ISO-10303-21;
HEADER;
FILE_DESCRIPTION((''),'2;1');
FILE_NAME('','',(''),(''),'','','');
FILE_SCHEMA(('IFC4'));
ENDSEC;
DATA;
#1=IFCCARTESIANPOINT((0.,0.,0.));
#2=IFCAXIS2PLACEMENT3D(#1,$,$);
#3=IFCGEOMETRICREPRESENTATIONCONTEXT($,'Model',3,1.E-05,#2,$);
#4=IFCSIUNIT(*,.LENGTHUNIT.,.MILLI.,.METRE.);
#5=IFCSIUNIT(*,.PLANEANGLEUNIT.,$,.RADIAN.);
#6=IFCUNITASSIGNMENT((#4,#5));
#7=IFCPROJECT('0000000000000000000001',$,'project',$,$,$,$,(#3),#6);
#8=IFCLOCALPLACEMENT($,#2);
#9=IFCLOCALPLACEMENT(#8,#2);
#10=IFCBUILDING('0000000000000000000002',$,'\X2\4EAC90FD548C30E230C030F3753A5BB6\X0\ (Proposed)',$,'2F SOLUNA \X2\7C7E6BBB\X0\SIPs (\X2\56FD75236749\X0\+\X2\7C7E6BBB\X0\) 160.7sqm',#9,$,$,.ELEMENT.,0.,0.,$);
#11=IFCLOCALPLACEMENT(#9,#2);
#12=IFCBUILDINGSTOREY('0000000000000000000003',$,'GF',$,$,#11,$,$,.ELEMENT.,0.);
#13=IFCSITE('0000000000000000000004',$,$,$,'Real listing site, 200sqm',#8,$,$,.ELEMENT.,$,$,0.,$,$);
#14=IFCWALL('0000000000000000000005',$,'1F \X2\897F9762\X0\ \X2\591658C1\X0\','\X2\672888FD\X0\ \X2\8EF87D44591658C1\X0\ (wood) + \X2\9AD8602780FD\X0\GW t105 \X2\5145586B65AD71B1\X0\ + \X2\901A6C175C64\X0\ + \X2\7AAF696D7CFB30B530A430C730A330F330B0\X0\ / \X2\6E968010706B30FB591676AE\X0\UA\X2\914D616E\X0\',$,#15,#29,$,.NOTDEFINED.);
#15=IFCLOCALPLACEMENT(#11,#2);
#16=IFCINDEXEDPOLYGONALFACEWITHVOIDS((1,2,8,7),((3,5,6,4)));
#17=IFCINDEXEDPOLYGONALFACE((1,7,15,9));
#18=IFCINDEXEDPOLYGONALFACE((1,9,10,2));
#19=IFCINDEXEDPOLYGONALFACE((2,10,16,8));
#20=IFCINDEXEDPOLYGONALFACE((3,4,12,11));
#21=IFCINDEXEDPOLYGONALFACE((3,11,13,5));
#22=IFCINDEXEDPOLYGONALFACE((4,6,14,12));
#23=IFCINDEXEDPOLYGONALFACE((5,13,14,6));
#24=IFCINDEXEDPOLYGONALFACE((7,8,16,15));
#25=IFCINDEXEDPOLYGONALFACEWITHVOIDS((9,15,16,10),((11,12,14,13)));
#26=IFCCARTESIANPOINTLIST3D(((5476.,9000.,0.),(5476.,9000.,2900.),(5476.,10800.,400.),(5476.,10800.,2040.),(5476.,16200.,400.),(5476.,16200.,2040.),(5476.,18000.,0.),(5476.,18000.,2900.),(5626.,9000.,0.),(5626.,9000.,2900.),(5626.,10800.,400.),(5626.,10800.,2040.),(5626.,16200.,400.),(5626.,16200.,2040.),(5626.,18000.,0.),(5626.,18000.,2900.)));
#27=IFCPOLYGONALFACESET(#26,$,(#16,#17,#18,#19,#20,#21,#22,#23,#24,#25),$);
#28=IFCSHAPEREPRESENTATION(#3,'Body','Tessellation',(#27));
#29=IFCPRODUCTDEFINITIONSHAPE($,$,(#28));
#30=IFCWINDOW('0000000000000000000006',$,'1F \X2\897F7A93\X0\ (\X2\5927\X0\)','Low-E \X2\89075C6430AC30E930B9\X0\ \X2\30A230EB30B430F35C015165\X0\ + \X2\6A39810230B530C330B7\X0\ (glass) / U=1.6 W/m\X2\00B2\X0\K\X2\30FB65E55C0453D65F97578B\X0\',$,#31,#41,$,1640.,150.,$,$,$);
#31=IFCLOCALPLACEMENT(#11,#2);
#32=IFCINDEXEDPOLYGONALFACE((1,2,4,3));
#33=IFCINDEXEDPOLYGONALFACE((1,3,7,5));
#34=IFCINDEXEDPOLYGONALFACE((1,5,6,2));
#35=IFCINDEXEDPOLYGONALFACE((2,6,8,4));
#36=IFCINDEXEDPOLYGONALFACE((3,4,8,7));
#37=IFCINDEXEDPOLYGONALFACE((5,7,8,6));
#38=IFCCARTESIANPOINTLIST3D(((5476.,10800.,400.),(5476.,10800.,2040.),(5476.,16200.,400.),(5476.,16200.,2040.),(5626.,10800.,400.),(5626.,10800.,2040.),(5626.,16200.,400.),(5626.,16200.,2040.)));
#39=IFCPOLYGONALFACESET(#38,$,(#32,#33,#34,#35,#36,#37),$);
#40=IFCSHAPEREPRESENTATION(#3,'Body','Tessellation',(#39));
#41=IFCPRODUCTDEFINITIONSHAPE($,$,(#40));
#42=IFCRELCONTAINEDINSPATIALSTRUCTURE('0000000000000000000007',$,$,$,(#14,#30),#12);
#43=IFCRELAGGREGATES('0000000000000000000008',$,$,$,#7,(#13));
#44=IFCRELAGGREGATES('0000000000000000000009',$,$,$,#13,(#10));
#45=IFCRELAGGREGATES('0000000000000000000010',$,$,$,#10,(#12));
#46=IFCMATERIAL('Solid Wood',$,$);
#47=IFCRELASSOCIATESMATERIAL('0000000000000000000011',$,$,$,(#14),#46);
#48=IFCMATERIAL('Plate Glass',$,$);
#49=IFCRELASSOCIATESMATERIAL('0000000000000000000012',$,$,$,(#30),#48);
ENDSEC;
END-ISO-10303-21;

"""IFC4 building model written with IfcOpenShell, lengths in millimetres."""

from ifc_helpers import new_model, si_unit, frame, frame_2d, origin, place, context, project, spatial, rectangle, extrude, material, element, fill, save


model = new_model("IFC4")

# Units and contexts
model_context = context("Model", 3, precision=1e-05, world=origin())
ifc_project = project(units=[si_unit("LENGTHUNIT", "METRE", prefix="MILLI"), si_unit("PLANEANGLEUNIT", "RADIAN")], contexts=[model_context])

# Site, building, storey
site_placement = place(None, origin())
site = spatial("IfcSite", under=ifc_project, at=site_placement, ObjectType="Real listing site, 200sqm", CompositionType="ELEMENT", RefElevation=0.0)
building_placement = place(site_placement, origin())
building = spatial("IfcBuilding", under=site, at=building_placement, Name="京都和モダン町家 (Proposed)", ObjectType="2F SOLUNA 籾殻SIPs (国産杉+籾殻) 160.7sqm", CompositionType="ELEMENT", ElevationOfRefHeight=0.0, ElevationOfTerrain=0.0)
storey_placement = place(building_placement, origin())
storey = spatial("IfcBuildingStorey", under=building, at=storey_placement, Name="GF", CompositionType="ELEMENT", Elevation=0.0)

# Shared definitions
ifc_material_1 = material(Name="Solid Wood")

# Shared definitions
ifc_material_2 = material(Name="Plate Glass")

# Wall, opening, window
wall_1_placement = place(storey_placement, frame((2738.0, 4500.0, 0.0)))
wall_1 = element("IfcWall", 1, at=wall_1_placement, inside=storey, material=ifc_material_1, Name="1F 西面 外壁", Description="木製 軸組外壁 (wood) + 高性能GW t105 充填断熱 + 通気層 + 窯業系サイディング / 準耐火・外皮UA配慮", PredefinedType="NOTDEFINED", context=model_context, shape_type="SweptSolid", body=[
    extrude(rectangle(XDim=150.0, YDim=9000.0, at=frame_2d((75.0, 4500.0))), frame((2738.0, 4500.0, 0.0)), (0.0, 0.0, 1.0), 2900.0),
])
opening_1_placement = place(storey_placement, frame((2738.0, 5400.0, 200.0)))
opening_1 = element("IfcOpeningElement", 2, at=opening_1_placement, cuts=wall_1, PredefinedType="NOTDEFINED", context=model_context, shape_type="SweptSolid", body=[
    extrude(rectangle(XDim=150.0, YDim=5400.0, at=frame_2d((75.0, 2700.0))), frame((2738.0, 5400.0, 200.0)), (0.0, 0.0, 1.0), 1640.0),
])
window_1_placement = place(storey_placement, frame((2738.0, 5400.0, 200.0)))
window_1 = element("IfcWindow", 3, at=window_1_placement, inside=storey, material=ifc_material_2, Name="1F 西窓 (大)", Description="Low-E 複層ガラス アルゴン封入 + 樹脂サッシ (glass) / U=1.6 W/m²K・日射取得型", OverallHeight=1640.0, OverallWidth=150.0, context=model_context, shape_type="SweptSolid", body=[
    extrude(rectangle(XDim=150.0, YDim=5400.0, at=frame_2d((75.0, 2700.0))), frame((2738.0, 5400.0, 200.0)), (0.0, 0.0, 1.0), 1640.0),
])
fill(opening_1, window_1)

save(model, "model.ifc")
